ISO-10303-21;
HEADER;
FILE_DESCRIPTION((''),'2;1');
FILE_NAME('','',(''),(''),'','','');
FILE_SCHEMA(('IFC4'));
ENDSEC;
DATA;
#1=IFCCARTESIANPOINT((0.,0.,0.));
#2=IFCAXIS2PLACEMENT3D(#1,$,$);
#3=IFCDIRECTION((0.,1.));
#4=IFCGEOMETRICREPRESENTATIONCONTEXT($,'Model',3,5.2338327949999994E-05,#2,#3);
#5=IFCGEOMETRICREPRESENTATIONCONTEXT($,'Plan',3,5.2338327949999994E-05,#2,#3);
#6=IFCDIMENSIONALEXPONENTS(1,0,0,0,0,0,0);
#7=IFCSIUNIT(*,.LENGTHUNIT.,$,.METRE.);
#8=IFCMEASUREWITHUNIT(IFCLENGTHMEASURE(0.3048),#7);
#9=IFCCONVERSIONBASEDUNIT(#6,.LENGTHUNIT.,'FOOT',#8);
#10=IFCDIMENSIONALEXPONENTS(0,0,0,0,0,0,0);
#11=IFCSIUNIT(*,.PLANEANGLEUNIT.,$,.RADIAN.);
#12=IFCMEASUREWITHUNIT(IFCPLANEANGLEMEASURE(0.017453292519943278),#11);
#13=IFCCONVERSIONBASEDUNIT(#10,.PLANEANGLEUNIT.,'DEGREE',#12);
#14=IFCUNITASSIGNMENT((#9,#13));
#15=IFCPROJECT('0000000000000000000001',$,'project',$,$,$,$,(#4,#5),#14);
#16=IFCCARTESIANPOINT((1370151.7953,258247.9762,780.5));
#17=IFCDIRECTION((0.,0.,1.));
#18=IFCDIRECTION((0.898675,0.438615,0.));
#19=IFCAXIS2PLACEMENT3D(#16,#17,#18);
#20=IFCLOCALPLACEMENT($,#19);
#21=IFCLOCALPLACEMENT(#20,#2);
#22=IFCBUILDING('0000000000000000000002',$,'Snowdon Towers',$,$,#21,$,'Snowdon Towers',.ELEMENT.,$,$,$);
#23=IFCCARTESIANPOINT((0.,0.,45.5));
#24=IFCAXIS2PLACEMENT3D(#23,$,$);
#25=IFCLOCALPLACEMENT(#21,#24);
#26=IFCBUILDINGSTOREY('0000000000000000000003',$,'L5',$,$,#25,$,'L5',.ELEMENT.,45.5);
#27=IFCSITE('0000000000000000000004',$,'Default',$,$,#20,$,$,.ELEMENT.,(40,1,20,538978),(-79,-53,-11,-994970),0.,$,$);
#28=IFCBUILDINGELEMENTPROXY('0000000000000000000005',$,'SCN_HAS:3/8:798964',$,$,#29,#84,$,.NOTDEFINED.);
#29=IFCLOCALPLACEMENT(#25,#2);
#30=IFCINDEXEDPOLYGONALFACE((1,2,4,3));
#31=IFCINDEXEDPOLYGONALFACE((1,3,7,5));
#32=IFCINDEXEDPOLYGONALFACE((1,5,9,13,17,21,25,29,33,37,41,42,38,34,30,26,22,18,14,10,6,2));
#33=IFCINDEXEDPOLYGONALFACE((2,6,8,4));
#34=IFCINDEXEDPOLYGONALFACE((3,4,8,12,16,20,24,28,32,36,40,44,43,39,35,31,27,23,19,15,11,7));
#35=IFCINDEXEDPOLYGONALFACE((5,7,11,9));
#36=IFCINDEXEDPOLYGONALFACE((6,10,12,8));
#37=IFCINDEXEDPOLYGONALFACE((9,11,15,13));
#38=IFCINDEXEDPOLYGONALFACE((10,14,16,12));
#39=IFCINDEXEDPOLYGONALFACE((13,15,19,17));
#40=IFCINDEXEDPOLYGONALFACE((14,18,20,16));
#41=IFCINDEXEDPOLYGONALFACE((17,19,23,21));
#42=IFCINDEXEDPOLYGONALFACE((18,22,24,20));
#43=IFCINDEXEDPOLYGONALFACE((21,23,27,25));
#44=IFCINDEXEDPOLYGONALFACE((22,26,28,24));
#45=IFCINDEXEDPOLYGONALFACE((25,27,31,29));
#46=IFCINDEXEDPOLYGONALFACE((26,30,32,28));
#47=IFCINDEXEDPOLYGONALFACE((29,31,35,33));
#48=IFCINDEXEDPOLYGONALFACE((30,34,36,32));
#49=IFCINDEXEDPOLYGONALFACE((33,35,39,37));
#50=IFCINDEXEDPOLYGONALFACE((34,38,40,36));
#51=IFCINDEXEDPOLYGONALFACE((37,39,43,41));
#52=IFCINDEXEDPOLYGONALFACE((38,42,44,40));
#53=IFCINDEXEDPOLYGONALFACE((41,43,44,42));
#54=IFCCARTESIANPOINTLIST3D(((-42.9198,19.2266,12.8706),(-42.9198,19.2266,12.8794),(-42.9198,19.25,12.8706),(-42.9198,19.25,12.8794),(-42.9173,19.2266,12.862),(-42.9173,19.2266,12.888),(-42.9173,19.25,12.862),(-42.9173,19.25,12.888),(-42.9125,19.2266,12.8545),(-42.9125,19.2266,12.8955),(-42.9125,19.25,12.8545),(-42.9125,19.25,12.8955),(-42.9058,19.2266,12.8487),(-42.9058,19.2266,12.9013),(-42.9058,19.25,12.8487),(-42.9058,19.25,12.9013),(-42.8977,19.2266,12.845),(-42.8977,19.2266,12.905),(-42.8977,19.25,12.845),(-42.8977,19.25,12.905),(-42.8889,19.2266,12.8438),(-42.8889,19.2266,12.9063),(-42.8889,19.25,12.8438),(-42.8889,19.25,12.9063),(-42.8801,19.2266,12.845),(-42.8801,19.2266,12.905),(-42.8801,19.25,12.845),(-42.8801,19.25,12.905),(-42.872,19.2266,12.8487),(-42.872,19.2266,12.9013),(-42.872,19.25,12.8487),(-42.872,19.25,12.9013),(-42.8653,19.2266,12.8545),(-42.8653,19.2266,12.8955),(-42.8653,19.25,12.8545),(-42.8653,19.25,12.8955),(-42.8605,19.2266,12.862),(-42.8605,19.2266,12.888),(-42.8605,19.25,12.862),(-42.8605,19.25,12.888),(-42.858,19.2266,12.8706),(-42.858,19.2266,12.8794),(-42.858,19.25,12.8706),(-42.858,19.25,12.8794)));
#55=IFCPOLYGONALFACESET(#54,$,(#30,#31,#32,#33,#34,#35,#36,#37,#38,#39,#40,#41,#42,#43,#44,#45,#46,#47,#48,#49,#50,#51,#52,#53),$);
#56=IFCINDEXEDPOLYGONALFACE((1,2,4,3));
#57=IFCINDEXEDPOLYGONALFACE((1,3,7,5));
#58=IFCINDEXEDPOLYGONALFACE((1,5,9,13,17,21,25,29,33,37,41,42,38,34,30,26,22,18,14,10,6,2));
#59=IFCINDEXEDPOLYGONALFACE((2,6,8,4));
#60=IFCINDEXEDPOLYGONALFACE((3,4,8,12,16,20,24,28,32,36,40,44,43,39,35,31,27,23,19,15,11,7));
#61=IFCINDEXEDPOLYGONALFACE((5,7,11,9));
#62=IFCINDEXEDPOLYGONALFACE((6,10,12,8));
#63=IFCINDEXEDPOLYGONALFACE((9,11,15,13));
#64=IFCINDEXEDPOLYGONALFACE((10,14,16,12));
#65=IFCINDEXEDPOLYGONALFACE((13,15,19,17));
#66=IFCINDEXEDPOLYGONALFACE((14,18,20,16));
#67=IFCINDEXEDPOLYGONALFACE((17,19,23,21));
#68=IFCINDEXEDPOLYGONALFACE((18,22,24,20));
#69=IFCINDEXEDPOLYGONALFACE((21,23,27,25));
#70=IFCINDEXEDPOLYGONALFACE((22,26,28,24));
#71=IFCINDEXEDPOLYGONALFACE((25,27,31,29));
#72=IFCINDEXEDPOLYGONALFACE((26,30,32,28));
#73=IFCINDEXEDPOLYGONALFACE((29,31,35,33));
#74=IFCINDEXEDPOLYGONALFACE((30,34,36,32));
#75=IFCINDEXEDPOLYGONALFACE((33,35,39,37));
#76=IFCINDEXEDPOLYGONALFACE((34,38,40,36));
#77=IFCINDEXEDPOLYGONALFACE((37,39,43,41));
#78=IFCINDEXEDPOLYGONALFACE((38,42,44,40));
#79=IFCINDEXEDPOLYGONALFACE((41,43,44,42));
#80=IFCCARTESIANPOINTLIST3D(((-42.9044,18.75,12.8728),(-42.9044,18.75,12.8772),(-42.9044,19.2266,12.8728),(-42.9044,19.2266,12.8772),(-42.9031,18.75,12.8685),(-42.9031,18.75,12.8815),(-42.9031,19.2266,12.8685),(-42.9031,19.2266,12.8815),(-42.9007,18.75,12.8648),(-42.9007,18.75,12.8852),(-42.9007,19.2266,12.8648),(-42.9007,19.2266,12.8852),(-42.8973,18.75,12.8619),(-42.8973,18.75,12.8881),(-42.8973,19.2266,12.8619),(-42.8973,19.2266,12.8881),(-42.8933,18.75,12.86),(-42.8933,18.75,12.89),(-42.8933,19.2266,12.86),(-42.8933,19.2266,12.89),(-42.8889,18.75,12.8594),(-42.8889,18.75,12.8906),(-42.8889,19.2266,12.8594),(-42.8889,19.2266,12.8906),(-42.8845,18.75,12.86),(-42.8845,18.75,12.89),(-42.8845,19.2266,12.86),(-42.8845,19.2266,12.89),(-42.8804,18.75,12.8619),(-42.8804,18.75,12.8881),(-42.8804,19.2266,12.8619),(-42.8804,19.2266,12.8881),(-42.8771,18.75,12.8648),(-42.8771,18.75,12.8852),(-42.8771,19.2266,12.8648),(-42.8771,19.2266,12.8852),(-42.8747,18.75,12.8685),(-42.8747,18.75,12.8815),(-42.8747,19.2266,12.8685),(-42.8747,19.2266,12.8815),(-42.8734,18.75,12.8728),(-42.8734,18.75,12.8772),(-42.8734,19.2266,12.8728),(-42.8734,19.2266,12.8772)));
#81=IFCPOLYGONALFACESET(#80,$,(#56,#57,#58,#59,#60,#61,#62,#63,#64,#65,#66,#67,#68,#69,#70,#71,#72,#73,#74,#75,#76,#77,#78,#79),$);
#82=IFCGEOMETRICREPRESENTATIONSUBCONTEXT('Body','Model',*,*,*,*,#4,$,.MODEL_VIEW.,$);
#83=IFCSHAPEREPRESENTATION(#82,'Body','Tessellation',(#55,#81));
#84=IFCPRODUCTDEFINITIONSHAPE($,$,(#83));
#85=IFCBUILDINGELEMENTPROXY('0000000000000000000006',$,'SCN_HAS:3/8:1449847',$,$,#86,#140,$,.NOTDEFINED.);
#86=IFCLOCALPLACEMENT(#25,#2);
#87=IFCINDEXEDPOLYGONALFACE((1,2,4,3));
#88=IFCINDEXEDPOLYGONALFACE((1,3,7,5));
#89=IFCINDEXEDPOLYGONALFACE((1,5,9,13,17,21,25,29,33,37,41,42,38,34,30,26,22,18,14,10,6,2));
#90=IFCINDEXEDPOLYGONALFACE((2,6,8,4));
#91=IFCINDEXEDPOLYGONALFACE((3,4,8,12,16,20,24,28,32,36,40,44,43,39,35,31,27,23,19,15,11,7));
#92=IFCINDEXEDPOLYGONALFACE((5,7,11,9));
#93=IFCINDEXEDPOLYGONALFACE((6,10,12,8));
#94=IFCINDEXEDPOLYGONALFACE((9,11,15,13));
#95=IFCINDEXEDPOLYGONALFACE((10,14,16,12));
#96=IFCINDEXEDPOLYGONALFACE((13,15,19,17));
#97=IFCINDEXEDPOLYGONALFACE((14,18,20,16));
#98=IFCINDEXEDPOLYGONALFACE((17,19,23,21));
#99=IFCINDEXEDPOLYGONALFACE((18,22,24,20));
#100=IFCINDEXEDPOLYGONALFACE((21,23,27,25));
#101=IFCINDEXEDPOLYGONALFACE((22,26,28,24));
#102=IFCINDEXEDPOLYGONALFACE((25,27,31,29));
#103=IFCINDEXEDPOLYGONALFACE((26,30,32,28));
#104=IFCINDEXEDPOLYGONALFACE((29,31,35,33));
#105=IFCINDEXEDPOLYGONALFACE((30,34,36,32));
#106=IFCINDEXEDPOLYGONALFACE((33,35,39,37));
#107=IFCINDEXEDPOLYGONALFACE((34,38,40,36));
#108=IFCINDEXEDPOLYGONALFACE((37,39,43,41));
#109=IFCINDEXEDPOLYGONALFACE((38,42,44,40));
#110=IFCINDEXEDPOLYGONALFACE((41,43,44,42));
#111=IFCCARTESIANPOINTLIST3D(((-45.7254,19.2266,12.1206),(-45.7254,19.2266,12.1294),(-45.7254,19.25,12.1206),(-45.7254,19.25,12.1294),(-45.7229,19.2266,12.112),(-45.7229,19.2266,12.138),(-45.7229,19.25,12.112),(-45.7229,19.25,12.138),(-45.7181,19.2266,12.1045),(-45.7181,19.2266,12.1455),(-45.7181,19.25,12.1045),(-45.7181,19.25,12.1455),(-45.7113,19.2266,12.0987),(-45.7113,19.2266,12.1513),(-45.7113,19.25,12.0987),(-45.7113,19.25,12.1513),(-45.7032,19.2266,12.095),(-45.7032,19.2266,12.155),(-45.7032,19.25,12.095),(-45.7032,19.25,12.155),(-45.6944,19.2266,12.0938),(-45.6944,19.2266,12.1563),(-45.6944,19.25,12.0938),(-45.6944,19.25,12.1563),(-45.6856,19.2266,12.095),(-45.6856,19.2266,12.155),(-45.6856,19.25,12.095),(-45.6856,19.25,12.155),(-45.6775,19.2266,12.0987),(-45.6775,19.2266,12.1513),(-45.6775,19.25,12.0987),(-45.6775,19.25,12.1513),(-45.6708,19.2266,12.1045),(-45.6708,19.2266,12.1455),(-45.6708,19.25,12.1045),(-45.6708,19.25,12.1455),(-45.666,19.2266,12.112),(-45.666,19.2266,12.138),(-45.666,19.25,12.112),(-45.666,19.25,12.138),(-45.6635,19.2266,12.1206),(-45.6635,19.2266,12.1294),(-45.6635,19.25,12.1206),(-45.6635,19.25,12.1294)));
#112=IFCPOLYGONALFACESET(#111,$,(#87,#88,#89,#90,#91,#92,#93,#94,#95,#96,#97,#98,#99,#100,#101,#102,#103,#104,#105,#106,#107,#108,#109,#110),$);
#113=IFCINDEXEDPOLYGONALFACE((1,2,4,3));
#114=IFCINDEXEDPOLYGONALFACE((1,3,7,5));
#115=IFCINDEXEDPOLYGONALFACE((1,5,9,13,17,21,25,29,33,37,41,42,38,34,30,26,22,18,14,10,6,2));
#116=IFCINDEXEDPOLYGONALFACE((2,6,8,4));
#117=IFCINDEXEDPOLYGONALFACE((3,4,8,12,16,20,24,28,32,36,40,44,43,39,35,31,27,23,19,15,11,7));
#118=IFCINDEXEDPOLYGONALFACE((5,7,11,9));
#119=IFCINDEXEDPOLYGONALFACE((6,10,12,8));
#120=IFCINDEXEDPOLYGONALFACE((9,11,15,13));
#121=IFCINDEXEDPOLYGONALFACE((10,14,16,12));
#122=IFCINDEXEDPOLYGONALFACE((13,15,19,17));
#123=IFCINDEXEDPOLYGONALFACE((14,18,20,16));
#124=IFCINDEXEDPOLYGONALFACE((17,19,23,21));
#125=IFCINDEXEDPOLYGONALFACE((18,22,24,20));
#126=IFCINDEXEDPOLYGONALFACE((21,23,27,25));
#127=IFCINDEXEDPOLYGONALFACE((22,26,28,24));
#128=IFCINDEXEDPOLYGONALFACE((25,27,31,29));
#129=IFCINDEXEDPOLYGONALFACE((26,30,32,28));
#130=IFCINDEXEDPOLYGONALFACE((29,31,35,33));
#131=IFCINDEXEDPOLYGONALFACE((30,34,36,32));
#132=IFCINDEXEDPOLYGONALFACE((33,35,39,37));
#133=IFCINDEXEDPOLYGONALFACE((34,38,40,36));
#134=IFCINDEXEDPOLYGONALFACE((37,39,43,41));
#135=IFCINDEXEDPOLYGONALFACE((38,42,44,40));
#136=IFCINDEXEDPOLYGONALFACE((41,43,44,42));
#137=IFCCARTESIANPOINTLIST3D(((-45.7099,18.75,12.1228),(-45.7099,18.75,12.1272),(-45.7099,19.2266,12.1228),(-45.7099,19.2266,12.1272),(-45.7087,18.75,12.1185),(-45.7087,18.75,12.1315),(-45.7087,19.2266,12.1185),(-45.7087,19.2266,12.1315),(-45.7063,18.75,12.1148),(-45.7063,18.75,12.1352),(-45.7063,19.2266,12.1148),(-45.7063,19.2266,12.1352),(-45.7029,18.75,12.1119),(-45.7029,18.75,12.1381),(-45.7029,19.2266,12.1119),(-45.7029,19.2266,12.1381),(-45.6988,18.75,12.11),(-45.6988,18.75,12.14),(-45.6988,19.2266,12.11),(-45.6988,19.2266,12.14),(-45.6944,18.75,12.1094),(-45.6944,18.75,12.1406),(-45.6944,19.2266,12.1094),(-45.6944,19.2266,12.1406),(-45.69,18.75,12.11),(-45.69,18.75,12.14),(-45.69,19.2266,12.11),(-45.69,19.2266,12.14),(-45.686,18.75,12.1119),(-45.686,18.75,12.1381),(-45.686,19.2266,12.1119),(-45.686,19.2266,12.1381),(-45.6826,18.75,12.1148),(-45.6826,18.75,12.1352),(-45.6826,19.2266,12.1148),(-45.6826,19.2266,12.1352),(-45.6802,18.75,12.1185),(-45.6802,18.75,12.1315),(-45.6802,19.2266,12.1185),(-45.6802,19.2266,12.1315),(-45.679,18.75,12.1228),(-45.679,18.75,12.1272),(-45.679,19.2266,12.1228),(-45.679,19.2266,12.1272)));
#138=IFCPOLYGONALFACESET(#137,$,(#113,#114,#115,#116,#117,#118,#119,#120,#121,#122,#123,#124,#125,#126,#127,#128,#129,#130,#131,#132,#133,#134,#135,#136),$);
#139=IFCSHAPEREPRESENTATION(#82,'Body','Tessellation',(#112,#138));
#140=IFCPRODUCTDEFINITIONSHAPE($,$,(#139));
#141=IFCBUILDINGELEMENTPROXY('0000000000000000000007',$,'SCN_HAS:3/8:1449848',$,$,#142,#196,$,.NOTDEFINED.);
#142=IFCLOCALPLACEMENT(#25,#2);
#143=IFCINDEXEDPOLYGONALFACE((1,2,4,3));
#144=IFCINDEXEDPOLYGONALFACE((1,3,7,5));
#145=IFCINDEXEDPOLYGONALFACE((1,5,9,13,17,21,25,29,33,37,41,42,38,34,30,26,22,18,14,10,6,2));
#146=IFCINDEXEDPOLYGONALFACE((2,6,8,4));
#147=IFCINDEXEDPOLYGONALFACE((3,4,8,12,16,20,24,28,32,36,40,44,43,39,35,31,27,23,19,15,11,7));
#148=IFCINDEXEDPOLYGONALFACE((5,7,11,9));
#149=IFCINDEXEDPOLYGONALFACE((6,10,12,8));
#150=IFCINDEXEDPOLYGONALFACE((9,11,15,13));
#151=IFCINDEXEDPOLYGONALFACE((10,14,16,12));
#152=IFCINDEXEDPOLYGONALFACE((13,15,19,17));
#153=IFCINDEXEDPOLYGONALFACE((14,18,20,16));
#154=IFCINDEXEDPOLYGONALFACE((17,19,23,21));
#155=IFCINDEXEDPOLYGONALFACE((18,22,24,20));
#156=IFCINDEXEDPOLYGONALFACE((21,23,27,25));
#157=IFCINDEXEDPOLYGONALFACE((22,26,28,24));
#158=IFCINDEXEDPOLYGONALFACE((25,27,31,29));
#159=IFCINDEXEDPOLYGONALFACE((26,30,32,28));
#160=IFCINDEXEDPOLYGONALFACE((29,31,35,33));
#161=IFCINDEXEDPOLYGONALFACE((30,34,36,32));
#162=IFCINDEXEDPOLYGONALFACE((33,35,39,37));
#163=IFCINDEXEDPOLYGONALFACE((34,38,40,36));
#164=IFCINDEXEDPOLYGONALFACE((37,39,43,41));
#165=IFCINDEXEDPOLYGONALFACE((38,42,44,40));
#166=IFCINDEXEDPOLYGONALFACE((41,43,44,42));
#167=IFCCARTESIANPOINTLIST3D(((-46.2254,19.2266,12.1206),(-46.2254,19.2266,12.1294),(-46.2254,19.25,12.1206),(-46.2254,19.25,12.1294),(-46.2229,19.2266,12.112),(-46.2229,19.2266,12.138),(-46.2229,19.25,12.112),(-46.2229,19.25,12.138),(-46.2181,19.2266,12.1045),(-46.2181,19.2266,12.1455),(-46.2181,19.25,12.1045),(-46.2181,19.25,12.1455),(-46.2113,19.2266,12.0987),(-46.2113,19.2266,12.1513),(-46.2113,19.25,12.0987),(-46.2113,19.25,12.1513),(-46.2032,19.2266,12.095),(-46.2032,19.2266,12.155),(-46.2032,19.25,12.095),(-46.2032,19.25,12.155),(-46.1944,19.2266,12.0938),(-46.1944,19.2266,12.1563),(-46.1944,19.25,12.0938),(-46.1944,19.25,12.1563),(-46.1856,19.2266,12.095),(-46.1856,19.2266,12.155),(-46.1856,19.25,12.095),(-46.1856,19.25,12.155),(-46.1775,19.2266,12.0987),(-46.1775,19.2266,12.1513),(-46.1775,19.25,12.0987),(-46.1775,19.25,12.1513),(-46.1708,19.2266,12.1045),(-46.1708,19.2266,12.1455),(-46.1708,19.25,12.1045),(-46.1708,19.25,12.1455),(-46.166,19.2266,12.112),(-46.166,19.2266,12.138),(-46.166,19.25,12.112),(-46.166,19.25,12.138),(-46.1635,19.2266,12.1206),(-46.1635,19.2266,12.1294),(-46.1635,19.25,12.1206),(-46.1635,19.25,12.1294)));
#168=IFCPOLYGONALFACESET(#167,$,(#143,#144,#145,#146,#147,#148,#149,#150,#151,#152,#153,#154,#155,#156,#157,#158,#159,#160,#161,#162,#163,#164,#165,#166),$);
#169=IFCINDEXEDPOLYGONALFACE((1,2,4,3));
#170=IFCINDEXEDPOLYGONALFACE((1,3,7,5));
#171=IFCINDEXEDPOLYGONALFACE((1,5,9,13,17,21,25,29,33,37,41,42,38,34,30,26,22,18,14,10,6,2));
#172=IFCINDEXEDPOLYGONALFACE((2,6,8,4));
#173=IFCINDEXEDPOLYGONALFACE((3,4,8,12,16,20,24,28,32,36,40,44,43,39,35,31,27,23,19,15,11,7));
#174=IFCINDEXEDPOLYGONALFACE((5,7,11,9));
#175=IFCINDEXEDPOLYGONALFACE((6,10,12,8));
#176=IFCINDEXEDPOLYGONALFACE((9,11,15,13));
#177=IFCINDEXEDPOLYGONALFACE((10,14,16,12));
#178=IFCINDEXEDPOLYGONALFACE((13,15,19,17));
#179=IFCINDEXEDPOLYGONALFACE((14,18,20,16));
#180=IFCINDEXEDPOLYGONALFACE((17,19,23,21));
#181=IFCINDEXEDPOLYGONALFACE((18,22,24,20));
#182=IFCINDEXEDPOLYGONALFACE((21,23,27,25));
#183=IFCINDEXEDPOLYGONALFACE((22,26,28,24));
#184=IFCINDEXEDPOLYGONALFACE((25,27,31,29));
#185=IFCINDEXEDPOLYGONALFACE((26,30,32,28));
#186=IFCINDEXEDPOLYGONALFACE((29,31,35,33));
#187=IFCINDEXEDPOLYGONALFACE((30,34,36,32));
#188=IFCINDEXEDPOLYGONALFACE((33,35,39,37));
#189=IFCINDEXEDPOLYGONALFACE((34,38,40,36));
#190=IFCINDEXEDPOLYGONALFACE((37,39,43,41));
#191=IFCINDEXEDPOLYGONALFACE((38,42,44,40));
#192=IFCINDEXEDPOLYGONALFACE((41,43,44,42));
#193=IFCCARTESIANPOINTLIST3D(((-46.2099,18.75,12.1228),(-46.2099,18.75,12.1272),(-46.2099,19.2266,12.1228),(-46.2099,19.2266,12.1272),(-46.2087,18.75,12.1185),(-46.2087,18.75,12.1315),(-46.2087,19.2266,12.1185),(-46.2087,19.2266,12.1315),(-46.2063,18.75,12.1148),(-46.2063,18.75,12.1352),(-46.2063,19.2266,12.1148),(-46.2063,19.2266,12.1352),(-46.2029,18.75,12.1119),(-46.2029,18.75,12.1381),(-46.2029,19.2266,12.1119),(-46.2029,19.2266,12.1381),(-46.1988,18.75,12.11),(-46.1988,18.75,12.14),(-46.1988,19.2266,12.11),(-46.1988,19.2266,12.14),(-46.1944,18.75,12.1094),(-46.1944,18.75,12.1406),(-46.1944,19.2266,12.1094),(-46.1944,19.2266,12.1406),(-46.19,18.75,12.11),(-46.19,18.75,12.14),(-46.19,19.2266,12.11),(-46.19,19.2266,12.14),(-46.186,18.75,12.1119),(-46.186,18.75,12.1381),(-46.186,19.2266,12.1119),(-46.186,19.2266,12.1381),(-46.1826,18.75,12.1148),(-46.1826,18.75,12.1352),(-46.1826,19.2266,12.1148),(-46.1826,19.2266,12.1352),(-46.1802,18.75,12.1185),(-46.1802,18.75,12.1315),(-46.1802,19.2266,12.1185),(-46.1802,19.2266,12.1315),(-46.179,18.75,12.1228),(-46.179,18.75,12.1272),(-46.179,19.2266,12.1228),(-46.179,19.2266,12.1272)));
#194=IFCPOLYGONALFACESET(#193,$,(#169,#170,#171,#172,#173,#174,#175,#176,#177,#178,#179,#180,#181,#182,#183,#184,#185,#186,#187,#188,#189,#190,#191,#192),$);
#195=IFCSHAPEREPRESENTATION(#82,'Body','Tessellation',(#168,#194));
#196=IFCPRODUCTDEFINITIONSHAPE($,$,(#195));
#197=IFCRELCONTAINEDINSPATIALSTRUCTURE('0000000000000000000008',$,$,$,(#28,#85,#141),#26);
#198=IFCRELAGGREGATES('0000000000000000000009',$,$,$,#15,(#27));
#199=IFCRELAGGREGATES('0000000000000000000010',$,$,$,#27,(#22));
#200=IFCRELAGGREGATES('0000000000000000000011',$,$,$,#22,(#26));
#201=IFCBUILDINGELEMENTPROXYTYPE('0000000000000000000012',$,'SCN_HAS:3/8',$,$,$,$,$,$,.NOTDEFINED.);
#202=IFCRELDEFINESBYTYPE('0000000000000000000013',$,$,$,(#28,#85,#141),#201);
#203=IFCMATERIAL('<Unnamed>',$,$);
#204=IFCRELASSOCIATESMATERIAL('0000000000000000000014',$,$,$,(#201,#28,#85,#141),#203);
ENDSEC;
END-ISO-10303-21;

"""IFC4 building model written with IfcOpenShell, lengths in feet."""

from ifc_helpers import new_model, entity, si_unit, converted_unit, direction, frame, origin, place, context, subcontext, project, spatial, arc, indexed_curve, outline, extrude, source, transform, mapped, material, type_object, type_shapes, element, save


model = new_model("IFC4")

# Units and contexts
model_context = context("Model", 3, precision=5.2338327949999994e-05, world=origin(), true_north=direction((0.0, 1.0)))
plan_context = context("Plan", 3, precision=5.2338327949999994e-05, world=origin(), true_north=direction((0.0, 1.0)))
body_context = subcontext(model_context, "Body", "Model", "MODEL_VIEW")
ifc_project = project(units=[converted_unit("LENGTHUNIT", "FOOT", entity("IfcLengthMeasure", 0.3048), si_unit("LENGTHUNIT", "METRE"), dimensions=[1, 0, 0, 0, 0, 0, 0]), converted_unit("PLANEANGLEUNIT", "DEGREE", entity("IfcPlaneAngleMeasure", 0.017453292519943278), si_unit("PLANEANGLEUNIT", "RADIAN"), dimensions=[0, 0, 0, 0, 0, 0, 0])], contexts=[model_context, plan_context])

# Site, building, storey
site_placement = place(None, frame((1370151.7953, 258247.9762, 780.5), z_axis=(0.0, 0.0, 1.0), x_axis=(0.898675, 0.438615, 0.0)))
site = spatial("IfcSite", under=ifc_project, at=site_placement, Name="Default", CompositionType="ELEMENT", RefLatitude=(40, 1, 20, 538978), RefLongitude=(-79, -53, -11, -994970), RefElevation=0.0)
building_placement = place(site_placement, origin())
building = spatial("IfcBuilding", under=site, at=building_placement, Name="Snowdon Towers", LongName="Snowdon Towers", CompositionType="ELEMENT")
storey_placement = place(building_placement, frame((0.0, 0.0, 45.5)))
storey = spatial("IfcBuildingStorey", under=building, at=storey_placement, Name="L5", LongName="L5", CompositionType="ELEMENT", Elevation=45.5)

# Building element proxies
ifc_material_1 = material(Name="<Unnamed>")
building_element_proxy_type_1 = type_object("IfcBuildingElementProxyType", Name="SCN_HAS:3/8", PredefinedType="NOTDEFINED", material=ifc_material_1)
shared_shape_1 = source(origin(), body_context, "Body", "SweptSolid", [
    extrude(outline(indexed_curve([(-0.0312, 0.0), (0.0, -0.0313), (0.0312, 0.0), (0.0, 0.0312)], segments=[arc(1, 2, 3), arc(3, 4, 1)], self_intersect=False)), frame((0.0, 0.0, -0.5), z_axis=(0.0, 0.0, 1.0), x_axis=(0.0, -1.0, 0.0)), (0.0, 0.0, 1.0), 0.0234),
    extrude(outline(indexed_curve([(-0.0156, 0.0), (0.0, -0.0156), (0.0156, 0.0), (0.0, 0.0156)], segments=[arc(1, 2, 3), arc(3, 4, 1)], self_intersect=False)), frame((0.0, 0.0, -0.4766), z_axis=(0.0, 0.0, 1.0), x_axis=(0.0, -1.0, 0.0)), (0.0, 0.0, 1.0), 0.4766),
])
type_shapes(building_element_proxy_type_1, [shared_shape_1])
for number, where, z_axis, x_axis, name in (
    (1, (-42.8889, 18.75, 12.875), (0.0, -1.0, 0.0), (1.0, 0.0, 0.0), "SCN_HAS:3/8:798964"),
    (2, (-45.6944, 18.75, 12.125), (0.0, -1.0, 0.0), (1.0, 0.0, 0.0), "SCN_HAS:3/8:1449847"),
    (3, (-46.1944, 18.75, 12.125), (0.0, -1.0, 0.0), (1.0, 0.0, 0.0), "SCN_HAS:3/8:1449848"),
):
    element("IfcBuildingElementProxy", number, at=place(storey_placement, frame(where, z_axis=z_axis, x_axis=x_axis)), inside=storey, type_object=building_element_proxy_type_1, material=ifc_material_1, Name=name, PredefinedType="NOTDEFINED", context=body_context, shape_type="MappedRepresentation", body=[
        mapped(shared_shape_1, transform((0.0, 0.0, 0.0), scale=1.0)),
    ])

save(model, "model.ifc")
